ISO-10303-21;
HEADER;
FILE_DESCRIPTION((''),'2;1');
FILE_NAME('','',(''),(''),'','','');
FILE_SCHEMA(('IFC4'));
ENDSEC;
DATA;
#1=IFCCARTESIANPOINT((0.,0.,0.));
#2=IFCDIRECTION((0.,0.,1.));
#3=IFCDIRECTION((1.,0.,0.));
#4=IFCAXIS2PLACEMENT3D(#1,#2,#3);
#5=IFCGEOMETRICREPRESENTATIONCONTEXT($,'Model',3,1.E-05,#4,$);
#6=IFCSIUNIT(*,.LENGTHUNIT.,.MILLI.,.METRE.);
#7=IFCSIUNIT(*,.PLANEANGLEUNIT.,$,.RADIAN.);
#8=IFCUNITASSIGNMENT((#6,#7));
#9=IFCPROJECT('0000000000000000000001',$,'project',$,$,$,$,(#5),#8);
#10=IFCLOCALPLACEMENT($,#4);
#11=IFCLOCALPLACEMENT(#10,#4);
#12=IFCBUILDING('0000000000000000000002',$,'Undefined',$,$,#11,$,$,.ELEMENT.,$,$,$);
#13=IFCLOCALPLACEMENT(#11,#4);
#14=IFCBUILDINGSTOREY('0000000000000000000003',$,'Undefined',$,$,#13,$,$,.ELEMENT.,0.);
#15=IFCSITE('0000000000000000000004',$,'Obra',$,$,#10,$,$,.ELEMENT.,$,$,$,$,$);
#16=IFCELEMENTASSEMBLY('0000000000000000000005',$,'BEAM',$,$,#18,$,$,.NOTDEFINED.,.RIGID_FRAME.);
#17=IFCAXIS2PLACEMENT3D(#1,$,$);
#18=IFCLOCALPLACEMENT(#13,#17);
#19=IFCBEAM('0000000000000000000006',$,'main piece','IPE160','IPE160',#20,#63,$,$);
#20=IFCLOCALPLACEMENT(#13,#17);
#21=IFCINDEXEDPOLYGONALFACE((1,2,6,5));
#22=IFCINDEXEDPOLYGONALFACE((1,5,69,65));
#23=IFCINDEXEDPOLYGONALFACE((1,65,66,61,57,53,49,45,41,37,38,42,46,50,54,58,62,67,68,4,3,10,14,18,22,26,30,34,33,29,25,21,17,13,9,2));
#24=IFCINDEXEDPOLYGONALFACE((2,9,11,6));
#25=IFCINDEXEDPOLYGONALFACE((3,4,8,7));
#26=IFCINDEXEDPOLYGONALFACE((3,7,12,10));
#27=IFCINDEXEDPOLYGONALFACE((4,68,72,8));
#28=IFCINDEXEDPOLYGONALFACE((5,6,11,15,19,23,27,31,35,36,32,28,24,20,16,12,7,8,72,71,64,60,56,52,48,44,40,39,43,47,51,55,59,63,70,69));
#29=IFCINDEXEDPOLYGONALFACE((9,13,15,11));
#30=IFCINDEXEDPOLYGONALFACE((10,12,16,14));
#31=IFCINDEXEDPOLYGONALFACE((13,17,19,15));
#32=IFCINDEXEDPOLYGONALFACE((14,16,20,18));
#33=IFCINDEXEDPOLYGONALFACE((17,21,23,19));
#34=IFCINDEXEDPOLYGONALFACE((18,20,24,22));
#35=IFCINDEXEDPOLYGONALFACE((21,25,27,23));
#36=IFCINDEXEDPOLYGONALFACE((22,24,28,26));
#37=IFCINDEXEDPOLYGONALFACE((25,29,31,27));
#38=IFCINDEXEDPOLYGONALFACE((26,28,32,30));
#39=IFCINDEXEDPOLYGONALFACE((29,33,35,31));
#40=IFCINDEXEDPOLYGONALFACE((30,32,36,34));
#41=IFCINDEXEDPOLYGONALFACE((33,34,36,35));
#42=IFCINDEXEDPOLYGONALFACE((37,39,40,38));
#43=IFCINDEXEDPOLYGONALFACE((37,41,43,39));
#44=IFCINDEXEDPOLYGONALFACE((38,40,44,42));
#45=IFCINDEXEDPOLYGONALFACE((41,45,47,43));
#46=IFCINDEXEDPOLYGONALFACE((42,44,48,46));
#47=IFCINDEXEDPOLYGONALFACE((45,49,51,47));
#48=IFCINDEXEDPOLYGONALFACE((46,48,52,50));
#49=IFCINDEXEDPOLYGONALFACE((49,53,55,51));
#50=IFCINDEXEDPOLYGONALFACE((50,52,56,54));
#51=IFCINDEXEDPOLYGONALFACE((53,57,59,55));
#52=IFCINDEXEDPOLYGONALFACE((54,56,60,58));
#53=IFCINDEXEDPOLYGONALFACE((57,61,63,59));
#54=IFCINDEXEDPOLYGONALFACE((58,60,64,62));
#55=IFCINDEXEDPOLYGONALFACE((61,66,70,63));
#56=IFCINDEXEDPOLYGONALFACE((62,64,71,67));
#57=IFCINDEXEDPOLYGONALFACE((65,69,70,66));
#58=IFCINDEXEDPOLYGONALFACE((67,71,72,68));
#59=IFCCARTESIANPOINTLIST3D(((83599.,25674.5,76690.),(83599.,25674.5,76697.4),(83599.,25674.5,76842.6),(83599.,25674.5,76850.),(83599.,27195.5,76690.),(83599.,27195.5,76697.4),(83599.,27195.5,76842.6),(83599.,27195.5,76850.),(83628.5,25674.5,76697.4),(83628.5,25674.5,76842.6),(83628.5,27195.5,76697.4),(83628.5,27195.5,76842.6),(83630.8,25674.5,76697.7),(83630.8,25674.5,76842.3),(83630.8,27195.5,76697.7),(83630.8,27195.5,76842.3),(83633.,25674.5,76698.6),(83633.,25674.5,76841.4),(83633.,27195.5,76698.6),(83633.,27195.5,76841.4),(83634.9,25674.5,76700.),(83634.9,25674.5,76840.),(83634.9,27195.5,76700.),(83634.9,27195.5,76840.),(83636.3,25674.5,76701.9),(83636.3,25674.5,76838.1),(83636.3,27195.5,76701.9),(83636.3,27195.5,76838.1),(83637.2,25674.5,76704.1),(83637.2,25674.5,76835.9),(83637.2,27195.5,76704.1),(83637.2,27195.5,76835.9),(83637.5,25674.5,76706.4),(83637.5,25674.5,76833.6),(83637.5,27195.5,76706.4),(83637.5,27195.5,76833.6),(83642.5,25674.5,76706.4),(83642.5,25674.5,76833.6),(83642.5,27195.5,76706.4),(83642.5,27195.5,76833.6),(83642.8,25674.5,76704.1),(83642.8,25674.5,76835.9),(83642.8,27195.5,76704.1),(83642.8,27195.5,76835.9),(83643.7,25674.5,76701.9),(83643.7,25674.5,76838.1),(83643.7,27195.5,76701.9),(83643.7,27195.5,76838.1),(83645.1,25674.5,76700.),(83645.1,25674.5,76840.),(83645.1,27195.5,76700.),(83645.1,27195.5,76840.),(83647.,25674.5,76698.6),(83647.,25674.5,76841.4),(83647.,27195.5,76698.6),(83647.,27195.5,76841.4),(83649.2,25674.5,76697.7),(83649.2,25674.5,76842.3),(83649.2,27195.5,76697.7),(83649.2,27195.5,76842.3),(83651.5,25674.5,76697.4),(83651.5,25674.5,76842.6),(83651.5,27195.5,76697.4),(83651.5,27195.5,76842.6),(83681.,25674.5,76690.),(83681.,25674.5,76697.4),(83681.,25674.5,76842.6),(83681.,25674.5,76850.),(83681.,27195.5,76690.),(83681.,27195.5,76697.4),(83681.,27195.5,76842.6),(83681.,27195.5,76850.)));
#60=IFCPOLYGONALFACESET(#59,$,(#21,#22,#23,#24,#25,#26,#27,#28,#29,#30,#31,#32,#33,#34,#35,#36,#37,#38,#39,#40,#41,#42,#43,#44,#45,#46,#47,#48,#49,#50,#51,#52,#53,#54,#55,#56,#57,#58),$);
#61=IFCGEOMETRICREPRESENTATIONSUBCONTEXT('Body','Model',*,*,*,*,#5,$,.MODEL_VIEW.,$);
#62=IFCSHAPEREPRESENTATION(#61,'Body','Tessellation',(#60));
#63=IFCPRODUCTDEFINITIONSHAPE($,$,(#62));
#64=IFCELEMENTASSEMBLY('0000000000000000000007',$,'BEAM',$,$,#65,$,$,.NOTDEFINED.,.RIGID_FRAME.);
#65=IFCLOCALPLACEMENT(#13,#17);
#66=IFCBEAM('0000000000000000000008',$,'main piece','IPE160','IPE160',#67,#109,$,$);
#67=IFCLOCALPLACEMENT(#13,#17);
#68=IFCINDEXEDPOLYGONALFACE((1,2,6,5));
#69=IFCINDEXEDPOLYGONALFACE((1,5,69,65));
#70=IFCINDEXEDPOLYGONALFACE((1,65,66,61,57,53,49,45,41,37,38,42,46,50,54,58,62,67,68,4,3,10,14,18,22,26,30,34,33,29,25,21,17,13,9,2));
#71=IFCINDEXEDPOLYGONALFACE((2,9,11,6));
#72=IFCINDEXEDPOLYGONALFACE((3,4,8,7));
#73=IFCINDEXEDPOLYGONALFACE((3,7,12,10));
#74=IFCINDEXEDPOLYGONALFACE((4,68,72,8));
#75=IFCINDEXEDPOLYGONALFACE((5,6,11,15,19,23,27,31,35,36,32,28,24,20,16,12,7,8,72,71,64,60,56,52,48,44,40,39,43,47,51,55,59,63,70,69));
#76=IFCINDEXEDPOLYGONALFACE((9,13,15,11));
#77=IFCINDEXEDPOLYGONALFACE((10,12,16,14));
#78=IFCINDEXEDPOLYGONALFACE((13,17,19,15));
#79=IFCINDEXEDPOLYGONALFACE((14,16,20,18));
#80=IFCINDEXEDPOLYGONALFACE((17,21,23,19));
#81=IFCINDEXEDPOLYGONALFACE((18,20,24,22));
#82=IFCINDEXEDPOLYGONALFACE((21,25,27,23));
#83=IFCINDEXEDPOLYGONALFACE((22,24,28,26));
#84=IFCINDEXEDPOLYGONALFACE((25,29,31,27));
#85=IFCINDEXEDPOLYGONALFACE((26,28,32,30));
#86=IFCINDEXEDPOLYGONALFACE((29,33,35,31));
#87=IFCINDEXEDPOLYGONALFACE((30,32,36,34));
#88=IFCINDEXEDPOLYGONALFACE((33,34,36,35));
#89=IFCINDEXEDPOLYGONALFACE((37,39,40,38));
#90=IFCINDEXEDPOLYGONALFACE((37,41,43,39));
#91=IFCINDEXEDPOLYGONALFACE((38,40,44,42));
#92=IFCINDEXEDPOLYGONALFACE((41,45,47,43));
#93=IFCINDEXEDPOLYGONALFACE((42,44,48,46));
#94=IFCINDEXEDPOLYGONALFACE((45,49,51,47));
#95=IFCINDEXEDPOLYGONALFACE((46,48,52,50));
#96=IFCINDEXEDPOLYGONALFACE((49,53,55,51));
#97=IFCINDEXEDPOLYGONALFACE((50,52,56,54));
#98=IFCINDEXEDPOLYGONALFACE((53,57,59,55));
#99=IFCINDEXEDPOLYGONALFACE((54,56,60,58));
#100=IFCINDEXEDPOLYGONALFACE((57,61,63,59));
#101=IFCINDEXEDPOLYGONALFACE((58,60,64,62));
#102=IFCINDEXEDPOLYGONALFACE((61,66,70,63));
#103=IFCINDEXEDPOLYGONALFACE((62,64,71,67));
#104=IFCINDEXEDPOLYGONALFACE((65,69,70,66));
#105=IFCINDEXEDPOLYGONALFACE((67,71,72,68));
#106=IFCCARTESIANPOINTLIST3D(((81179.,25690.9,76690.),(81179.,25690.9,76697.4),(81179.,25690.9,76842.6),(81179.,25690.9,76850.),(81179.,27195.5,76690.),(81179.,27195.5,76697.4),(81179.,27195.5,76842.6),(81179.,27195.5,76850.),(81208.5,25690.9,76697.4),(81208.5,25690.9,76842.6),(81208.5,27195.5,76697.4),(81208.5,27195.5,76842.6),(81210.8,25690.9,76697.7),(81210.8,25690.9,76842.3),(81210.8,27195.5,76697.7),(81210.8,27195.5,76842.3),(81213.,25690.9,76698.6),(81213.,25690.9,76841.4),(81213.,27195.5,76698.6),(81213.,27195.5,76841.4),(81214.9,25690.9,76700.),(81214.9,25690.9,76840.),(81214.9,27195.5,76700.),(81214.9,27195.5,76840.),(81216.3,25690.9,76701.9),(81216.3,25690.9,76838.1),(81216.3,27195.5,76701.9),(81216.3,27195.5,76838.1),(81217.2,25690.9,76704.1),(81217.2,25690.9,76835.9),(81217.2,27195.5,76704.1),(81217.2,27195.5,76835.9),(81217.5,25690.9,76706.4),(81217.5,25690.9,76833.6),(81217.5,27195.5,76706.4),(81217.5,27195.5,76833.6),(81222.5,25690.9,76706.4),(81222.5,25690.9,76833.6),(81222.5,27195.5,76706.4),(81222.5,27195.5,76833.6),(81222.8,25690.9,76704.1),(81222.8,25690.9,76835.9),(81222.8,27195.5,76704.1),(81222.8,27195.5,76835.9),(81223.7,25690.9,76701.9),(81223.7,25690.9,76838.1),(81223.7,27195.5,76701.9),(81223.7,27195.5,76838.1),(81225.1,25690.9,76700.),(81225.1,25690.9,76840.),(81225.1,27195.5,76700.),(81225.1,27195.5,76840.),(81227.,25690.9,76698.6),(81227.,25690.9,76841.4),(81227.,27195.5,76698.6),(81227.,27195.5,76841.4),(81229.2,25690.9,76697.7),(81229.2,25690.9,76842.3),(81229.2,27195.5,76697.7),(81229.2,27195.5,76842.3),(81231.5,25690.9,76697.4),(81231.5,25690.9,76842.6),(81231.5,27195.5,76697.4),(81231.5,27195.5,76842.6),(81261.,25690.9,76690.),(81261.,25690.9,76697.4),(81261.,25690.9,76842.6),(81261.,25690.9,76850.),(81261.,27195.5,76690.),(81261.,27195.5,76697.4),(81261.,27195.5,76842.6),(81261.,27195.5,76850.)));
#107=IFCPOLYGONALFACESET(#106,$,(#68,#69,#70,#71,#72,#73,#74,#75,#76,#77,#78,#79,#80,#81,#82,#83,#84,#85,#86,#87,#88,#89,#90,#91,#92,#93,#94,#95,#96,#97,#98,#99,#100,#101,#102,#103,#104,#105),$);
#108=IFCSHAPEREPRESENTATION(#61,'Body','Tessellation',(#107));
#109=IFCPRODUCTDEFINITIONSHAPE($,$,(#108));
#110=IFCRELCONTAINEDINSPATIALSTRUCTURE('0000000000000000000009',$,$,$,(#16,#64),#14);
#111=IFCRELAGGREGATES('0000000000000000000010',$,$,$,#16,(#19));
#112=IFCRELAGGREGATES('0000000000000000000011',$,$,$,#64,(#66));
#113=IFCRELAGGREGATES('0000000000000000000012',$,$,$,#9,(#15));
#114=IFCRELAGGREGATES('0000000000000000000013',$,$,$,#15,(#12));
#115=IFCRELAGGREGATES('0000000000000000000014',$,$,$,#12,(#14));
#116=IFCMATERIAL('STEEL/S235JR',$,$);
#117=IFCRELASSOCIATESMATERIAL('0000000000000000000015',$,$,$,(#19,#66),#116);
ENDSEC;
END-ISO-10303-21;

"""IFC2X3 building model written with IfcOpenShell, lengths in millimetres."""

from ifc_helpers import new_model, si_unit, frame, origin_with_axes, origin_2d_with_axis, place, context, subcontext, project, spatial, i_section, extrude, material, element, aggregate, save


model = new_model("IFC2X3")

# Units and contexts
model_context = context("Model", 3, precision=1e-05, world=origin_with_axes())
body_context = subcontext(model_context, "Body", "Model", "MODEL_VIEW")
ifc_project = project(units=[si_unit("LENGTHUNIT", "METRE", prefix="MILLI"), si_unit("PLANEANGLEUNIT", "RADIAN")], contexts=[model_context])

# Site, building, storey
site_placement = place(None, origin_with_axes())
site = spatial("IfcSite", under=ifc_project, at=site_placement, Name="Obra", CompositionType="ELEMENT")
building_placement = place(site_placement, origin_with_axes())
building = spatial("IfcBuilding", under=site, at=building_placement, Name="Undefined", CompositionType="ELEMENT")
storey_placement = place(building_placement, origin_with_axes())
storey = spatial("IfcBuildingStorey", under=building, at=storey_placement, Name="Undefined", CompositionType="ELEMENT", Elevation=0.0)

# Element assemblies, beams
ifc_material = material(Name="STEEL/S235JR")
assembly_1_placement = place(storey_placement, origin_with_axes())
assembly_1 = element("IfcElementAssembly", 1, at=assembly_1_placement, inside=storey, Name="BEAM", AssemblyPlace="NOTDEFINED", PredefinedType="RIGID_FRAME")
beam_1_placement = place(assembly_1_placement, frame((83640.0, 25674.5, 76770.0), z_axis=(0.0, 0.0, 1.0), x_axis=(0.000003, 1.0, 0.0)))
beam_1 = element("IfcBeam", 2, at=beam_1_placement, material=ifc_material, Name="main piece", Description="IPE160", ObjectType="IPE160", context=body_context, shape_type="SweptSolid", body=[
    extrude(i_section(OverallWidth=82.0, OverallDepth=160.0, WebThickness=5.0, FlangeThickness=7.4, FilletRadius=9.0, at=origin_2d_with_axis()), frame((1521.0, 0.0, 0.0), z_axis=(-1.0, 0.0, 0.0), x_axis=(0.0, -1.0, 0.0)), (0.0, 0.0, 1.0), 1521.0),
])
aggregate(assembly_1, [beam_1])
assembly_2_placement = place(storey_placement, origin_with_axes())
assembly_2 = element("IfcElementAssembly", 3, at=assembly_2_placement, inside=storey, Name="BEAM", AssemblyPlace="NOTDEFINED", PredefinedType="RIGID_FRAME")
beam_2_placement = place(assembly_2_placement, frame((81220.0, 25690.9, 76770.0), z_axis=(0.0, 0.0, 1.0), x_axis=(-0.000002, 1.0, 0.0)))
beam_2 = element("IfcBeam", 4, at=beam_2_placement, material=ifc_material, Name="main piece", Description="IPE160", ObjectType="IPE160", context=body_context, shape_type="SweptSolid", body=[
    extrude(i_section(OverallWidth=82.0, OverallDepth=160.0, WebThickness=5.0, FlangeThickness=7.4, FilletRadius=9.0, at=origin_2d_with_axis()), frame((1504.6, 0.0, 0.0), z_axis=(-1.0, 0.0, 0.0), x_axis=(0.0, -1.0, 0.0)), (0.0, 0.0, 1.0), 1504.6),
])
aggregate(assembly_2, [beam_2])

save(model, "model.ifc")
